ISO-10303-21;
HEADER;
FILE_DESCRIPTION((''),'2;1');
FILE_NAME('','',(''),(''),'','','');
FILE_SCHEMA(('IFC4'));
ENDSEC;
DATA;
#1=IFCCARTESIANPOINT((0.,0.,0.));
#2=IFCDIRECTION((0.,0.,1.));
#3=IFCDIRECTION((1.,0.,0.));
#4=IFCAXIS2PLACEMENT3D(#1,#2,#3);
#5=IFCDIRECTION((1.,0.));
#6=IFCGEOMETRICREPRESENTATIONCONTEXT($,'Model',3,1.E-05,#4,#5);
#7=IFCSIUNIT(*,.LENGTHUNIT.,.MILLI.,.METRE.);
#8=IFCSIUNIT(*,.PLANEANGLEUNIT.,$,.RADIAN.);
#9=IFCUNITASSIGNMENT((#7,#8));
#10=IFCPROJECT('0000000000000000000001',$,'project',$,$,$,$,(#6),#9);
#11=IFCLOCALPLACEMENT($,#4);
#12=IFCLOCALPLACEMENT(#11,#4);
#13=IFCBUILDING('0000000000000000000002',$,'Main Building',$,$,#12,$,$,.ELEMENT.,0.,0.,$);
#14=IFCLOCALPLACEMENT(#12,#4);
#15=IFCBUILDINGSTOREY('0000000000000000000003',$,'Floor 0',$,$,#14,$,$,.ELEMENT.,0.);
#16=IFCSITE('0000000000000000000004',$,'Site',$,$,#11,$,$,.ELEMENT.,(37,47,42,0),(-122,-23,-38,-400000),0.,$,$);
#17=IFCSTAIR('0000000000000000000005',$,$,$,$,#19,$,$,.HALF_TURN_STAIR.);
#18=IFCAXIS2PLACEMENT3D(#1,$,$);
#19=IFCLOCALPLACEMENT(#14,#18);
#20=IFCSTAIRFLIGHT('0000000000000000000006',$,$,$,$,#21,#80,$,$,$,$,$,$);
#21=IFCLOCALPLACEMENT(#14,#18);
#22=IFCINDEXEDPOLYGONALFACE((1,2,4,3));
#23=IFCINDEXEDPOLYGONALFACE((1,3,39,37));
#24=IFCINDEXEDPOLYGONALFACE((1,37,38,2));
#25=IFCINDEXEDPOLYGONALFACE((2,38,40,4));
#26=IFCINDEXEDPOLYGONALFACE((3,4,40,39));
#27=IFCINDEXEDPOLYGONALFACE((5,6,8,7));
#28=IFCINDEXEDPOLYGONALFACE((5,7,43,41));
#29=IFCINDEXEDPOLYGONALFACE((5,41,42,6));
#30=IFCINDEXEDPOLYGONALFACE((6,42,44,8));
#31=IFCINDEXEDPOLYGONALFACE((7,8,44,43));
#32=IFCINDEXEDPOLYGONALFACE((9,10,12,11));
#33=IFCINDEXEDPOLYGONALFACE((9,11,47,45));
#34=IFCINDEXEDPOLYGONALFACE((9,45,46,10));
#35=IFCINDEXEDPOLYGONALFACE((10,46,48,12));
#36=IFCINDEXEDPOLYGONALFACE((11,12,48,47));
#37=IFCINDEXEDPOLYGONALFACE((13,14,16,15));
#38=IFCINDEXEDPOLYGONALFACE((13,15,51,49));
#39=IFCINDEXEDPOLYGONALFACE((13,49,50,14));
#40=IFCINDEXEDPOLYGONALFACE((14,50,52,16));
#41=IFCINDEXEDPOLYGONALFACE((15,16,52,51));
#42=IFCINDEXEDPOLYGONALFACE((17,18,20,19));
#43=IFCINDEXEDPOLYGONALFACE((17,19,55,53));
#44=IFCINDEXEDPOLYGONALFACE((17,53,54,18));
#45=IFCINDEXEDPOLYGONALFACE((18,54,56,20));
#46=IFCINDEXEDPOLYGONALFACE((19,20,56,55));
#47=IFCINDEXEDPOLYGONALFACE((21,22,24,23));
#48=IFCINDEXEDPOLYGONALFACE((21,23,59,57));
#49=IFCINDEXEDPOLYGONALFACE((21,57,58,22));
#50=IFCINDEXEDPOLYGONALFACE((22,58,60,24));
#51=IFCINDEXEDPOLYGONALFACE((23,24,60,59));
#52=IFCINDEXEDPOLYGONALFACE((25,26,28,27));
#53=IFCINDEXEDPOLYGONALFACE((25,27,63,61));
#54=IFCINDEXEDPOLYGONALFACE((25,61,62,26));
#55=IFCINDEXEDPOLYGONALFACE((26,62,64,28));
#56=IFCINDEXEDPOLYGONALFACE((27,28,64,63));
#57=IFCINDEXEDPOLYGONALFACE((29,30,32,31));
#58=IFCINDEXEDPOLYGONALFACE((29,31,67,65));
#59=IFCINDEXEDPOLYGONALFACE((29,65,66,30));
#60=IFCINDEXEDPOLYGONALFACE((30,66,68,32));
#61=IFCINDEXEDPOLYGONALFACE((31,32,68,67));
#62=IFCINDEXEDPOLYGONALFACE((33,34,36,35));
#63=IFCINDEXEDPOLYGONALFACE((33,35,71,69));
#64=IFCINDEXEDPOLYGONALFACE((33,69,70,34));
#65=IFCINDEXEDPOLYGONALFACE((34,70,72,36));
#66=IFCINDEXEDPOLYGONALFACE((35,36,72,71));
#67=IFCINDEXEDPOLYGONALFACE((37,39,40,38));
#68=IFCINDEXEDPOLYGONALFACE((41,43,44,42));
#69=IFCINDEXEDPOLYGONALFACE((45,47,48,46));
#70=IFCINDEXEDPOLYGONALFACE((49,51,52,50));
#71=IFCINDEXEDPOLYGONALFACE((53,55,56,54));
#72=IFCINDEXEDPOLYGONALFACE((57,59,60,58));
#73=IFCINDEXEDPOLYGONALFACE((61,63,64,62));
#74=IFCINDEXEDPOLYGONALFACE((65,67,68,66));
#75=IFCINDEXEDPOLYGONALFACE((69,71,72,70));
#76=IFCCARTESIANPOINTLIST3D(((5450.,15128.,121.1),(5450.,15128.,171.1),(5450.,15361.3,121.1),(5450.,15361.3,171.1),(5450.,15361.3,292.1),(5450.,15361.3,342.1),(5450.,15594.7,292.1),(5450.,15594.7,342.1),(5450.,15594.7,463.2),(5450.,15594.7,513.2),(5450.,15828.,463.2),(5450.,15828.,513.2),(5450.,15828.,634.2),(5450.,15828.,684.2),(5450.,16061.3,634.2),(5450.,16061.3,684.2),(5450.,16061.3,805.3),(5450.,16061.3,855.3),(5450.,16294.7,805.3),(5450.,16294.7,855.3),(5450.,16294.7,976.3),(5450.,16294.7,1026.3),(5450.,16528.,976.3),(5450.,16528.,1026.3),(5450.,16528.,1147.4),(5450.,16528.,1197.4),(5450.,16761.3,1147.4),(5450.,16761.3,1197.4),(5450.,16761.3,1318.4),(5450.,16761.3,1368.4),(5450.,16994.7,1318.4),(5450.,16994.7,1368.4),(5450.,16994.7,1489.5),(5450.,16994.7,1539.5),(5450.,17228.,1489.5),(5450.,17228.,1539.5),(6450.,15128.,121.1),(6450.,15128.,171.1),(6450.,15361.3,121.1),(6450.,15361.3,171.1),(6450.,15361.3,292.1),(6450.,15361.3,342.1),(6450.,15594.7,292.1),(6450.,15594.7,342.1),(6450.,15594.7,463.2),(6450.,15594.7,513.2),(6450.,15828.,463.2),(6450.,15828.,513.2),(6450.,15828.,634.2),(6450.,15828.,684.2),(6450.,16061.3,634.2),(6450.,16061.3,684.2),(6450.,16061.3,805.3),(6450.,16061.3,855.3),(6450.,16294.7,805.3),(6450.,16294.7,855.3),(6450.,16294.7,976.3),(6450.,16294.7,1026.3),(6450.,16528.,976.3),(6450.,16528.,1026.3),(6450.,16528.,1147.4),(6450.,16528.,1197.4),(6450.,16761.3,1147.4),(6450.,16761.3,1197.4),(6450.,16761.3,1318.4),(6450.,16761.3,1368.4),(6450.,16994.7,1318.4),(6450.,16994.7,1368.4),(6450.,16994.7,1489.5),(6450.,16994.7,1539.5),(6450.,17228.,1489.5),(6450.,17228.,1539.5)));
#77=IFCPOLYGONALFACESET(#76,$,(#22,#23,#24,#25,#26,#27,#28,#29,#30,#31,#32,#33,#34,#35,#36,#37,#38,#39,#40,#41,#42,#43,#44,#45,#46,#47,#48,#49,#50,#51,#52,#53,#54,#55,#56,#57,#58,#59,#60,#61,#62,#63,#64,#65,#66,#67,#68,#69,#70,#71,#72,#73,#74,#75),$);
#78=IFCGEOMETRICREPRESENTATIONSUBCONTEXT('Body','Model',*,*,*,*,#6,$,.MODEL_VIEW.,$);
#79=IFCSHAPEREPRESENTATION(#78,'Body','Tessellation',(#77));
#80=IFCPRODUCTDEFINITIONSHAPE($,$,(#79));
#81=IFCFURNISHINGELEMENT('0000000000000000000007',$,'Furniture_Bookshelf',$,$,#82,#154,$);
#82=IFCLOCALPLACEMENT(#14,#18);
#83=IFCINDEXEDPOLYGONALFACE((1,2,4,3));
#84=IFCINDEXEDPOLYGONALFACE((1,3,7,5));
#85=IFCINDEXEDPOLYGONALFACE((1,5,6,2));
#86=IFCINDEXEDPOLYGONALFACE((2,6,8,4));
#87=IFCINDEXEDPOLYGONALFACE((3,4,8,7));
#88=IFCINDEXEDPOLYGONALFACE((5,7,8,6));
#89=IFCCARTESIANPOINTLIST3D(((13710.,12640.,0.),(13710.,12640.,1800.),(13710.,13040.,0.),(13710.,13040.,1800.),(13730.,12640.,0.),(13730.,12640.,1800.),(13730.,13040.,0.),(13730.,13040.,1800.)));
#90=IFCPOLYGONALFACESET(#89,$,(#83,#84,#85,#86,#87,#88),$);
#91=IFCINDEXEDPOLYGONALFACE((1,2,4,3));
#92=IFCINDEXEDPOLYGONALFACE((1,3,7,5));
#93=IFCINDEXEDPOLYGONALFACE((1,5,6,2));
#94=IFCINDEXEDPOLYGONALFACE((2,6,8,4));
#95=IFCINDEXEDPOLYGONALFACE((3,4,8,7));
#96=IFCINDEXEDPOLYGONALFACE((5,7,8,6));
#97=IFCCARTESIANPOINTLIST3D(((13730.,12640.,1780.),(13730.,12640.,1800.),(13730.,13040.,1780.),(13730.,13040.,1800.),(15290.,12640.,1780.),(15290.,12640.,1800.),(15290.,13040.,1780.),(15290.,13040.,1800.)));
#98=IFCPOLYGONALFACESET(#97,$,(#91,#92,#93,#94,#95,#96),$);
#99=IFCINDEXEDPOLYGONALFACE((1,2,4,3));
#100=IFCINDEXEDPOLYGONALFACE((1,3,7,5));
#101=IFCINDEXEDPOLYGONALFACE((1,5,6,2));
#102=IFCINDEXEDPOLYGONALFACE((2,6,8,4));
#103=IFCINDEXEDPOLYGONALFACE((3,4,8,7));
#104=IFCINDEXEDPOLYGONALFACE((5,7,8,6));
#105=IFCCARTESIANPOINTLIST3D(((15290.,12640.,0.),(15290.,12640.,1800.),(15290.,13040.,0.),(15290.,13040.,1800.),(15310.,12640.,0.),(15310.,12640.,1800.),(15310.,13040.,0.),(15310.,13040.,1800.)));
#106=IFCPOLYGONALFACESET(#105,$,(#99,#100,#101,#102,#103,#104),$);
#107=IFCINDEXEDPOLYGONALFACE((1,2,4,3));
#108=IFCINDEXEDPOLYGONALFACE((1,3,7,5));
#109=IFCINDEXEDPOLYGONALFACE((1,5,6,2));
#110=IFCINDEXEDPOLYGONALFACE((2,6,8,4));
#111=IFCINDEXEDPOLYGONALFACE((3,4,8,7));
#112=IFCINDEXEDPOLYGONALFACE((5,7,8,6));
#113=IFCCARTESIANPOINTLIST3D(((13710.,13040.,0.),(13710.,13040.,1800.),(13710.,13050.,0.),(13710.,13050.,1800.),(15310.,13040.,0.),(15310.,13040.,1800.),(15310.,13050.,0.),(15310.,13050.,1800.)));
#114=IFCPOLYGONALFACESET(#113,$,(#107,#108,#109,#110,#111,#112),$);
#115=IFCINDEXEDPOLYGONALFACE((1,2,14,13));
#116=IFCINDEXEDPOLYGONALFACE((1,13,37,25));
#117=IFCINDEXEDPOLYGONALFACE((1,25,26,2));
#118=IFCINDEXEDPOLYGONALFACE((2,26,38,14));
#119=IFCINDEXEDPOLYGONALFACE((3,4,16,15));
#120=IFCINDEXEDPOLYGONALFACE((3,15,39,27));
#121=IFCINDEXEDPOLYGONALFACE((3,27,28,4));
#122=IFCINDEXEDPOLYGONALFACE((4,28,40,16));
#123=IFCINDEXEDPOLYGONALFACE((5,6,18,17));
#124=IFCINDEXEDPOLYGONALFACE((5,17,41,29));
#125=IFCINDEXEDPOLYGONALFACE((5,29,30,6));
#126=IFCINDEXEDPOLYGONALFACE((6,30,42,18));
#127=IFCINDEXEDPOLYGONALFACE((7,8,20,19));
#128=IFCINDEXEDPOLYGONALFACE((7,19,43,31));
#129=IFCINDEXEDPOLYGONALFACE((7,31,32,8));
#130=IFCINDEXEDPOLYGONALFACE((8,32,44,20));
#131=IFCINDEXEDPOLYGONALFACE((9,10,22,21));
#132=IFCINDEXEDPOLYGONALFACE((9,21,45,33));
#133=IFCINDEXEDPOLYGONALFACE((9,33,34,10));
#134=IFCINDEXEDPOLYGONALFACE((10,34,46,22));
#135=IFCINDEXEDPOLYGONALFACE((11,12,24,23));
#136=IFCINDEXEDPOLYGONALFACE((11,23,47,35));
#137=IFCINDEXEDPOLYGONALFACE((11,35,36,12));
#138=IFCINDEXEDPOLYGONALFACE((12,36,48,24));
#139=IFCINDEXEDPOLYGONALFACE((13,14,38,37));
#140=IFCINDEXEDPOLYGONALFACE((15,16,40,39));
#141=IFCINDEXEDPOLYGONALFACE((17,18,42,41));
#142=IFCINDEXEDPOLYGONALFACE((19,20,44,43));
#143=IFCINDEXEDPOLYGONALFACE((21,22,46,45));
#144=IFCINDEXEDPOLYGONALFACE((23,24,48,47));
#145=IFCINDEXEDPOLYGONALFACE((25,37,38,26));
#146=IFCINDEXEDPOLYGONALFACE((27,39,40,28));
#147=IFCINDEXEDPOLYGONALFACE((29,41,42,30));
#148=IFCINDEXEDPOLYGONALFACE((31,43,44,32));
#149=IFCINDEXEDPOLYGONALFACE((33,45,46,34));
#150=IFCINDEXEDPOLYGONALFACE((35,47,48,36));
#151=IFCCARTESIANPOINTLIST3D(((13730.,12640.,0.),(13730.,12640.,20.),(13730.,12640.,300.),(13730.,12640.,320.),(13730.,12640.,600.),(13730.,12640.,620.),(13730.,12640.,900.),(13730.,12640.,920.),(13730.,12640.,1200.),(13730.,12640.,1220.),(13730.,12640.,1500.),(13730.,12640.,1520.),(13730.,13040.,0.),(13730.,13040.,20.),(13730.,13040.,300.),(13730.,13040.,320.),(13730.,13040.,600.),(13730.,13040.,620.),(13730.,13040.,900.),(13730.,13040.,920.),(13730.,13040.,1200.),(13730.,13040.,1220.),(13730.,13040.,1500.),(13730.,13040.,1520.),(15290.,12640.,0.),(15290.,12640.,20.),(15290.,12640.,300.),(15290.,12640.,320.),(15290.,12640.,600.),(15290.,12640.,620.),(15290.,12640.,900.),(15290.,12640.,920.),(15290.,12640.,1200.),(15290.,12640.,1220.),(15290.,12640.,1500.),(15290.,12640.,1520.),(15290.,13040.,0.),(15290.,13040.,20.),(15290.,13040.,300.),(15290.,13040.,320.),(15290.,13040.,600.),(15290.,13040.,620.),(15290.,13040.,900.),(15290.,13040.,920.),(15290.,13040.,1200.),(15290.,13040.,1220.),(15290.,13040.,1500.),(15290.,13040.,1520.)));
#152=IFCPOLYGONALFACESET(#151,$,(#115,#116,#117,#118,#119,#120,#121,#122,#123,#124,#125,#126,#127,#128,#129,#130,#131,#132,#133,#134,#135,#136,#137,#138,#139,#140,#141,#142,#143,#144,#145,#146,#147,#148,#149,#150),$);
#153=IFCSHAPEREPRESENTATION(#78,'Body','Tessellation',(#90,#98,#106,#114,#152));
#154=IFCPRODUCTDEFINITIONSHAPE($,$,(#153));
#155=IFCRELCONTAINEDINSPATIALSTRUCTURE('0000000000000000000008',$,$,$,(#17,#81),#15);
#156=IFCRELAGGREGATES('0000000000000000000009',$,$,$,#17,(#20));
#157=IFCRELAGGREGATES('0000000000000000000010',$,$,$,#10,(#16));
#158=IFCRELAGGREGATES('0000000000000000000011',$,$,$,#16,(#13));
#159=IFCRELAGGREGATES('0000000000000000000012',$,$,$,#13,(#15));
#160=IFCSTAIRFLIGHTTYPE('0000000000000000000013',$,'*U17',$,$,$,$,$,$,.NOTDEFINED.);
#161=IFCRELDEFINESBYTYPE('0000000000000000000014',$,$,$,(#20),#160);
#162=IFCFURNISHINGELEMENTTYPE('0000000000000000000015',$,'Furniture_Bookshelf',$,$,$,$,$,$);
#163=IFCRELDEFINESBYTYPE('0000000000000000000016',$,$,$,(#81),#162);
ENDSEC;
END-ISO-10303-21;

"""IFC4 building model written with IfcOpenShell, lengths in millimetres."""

from ifc_helpers import new_model, si_unit, direction, frame, frame_2d, origin_with_axes, origin_2d_with_axis, place, context, subcontext, project, spatial, rectangle, extrude, source, transform, mapped, type_object, type_shapes, element, aggregate, save


model = new_model("IFC4")

# Units and contexts
model_context = context("Model", 3, precision=1e-05, world=origin_with_axes(), true_north=direction((1.0, 0.0)))
body_context = subcontext(model_context, "Body", "Model", "MODEL_VIEW")
ifc_project = project(units=[si_unit("LENGTHUNIT", "METRE", prefix="MILLI"), si_unit("PLANEANGLEUNIT", "RADIAN")], contexts=[model_context])

# Site, building, storey
site_placement = place(None, origin_with_axes())
site = spatial("IfcSite", under=ifc_project, at=site_placement, Name="Site", CompositionType="ELEMENT", RefLatitude=(37, 47, 42, 0), RefLongitude=(-122, -23, -38, -400000), RefElevation=0.0)
building_placement = place(site_placement, origin_with_axes())
building = spatial("IfcBuilding", under=site, at=building_placement, Name="Main Building", CompositionType="ELEMENT", ElevationOfRefHeight=0.0, ElevationOfTerrain=0.0)
storey_placement = place(building_placement, origin_with_axes())
storey = spatial("IfcBuildingStorey", under=building, at=storey_placement, Name="Floor 0", CompositionType="ELEMENT", Elevation=0.0)

# Stair, stair flight
stair_placement = place(storey_placement, frame((8550.0, 15128.0, 3250.0), z_axis=(0.0, 0.0, 1.0), x_axis=(0.0, 1.0, 0.0)))
stair = element("IfcStair", 1, at=stair_placement, inside=storey, PredefinedType="HALF_TURN_STAIR")
stair_flight_type_1 = type_object("IfcStairFlightType", Name="*U17", PredefinedType="NOTDEFINED")
shared_shape_1 = source(origin_with_axes(), body_context, "Body", "SweptSolid", [
    extrude(rectangle(XDim=1000.0, YDim=233.3, at=frame_2d((0.0, 0.0), x_axis=(0.0, 1.0))), frame((1983.3, 2600.0, -1760.5), z_axis=(0.0, 0.0, 1.0), x_axis=(1.0, 0.0, 0.0)), (0.0, 0.0, 1.0), 50.0),
])
shared_shape_2 = source(origin_with_axes(), body_context, "Body", "MappedRepresentation", [
    mapped(shared_shape_1, transform((0.0, 0.0, 0.0), x_axis=(1.0, 0.0, 0.0), y_axis=(0.0, 1.0, 0.0), z_axis=(0.0, 0.0, 1.0), scale=1.0)),
    mapped(shared_shape_1, transform((-233.3, 0.0, -171.1), x_axis=(1.0, 0.0, 0.0), y_axis=(0.0, 1.0, 0.0), z_axis=(0.0, 0.0, 1.0), scale=1.0)),
    mapped(shared_shape_1, transform((-466.7, 0.0, -342.1), x_axis=(1.0, 0.0, 0.0), y_axis=(0.0, 1.0, 0.0), z_axis=(0.0, 0.0, 1.0), scale=1.0)),
    mapped(shared_shape_1, transform((-700.0, 0.0, -513.2), x_axis=(1.0, 0.0, 0.0), y_axis=(0.0, 1.0, 0.0), z_axis=(0.0, 0.0, 1.0), scale=1.0)),
    mapped(shared_shape_1, transform((-933.3, 0.0, -684.2), x_axis=(1.0, 0.0, 0.0), y_axis=(0.0, 1.0, 0.0), z_axis=(0.0, 0.0, 1.0), scale=1.0)),
    mapped(shared_shape_1, transform((-1166.7, 0.0, -855.3), x_axis=(1.0, 0.0, 0.0), y_axis=(0.0, 1.0, 0.0), z_axis=(0.0, 0.0, 1.0), scale=1.0)),
    mapped(shared_shape_1, transform((-1400.0, 0.0, -1026.3), x_axis=(1.0, 0.0, 0.0), y_axis=(0.0, 1.0, 0.0), z_axis=(0.0, 0.0, 1.0), scale=1.0)),
    mapped(shared_shape_1, transform((-1633.3, 0.0, -1197.4), x_axis=(1.0, 0.0, 0.0), y_axis=(0.0, 1.0, 0.0), z_axis=(0.0, 0.0, 1.0), scale=1.0)),
    mapped(shared_shape_1, transform((-1866.7, 0.0, -1368.4), x_axis=(1.0, 0.0, 0.0), y_axis=(0.0, 1.0, 0.0), z_axis=(0.0, 0.0, 1.0), scale=1.0)),
])
type_shapes(stair_flight_type_1, [shared_shape_2])
stair_flight_1_placement = place(stair_placement, origin_with_axes())
stair_flight_1 = element("IfcStairFlight", 2, at=stair_flight_1_placement, type_object=stair_flight_type_1, context=body_context, shape_type="MappedRepresentation", body=[
    mapped(shared_shape_2, transform((0.0, 0.0, 0.0), x_axis=(1.0, 0.0, 0.0), y_axis=(0.0, 1.0, 0.0), z_axis=(0.0, 0.0, 1.0), scale=1.0)),
])

# Furnishing element
furnishing_element_type_1 = type_object("IfcFurnishingElementType", Name="Furniture_Bookshelf")
shared_shape_3 = source(origin_with_axes(), body_context, "Body", "SweptSolid", [
    extrude(rectangle(XDim=400.0, YDim=20.0, at=frame_2d((0.0, 0.0), x_axis=(0.0, 1.0))), frame((10.0, 200.0, 0.0), z_axis=(0.0, 0.0, 1.0), x_axis=(1.0, 0.0, 0.0)), (0.0, 0.0, 1.0), 1800.0),
])
shared_shape_4 = source(origin_with_axes(), body_context, "Body", "SweptSolid", [
    extrude(rectangle(XDim=1560.0, YDim=400.0, at=origin_2d_with_axis()), frame((800.0, 200.0, 1780.0), z_axis=(0.0, 0.0, 1.0), x_axis=(1.0, 0.0, 0.0)), (0.0, 0.0, 1.0), 20.0),
])
shared_shape_5 = source(origin_with_axes(), body_context, "Body", "SweptSolid", [
    extrude(rectangle(XDim=400.0, YDim=20.0, at=frame_2d((0.0, 0.0), x_axis=(0.0, 1.0))), frame((1590.0, 200.0, 0.0), z_axis=(0.0, 0.0, 1.0), x_axis=(1.0, 0.0, 0.0)), (0.0, 0.0, 1.0), 1800.0),
])
shared_shape_6 = source(origin_with_axes(), body_context, "Body", "SweptSolid", [
    extrude(rectangle(XDim=1600.0, YDim=10.0, at=origin_2d_with_axis()), frame((800.0, 405.0, 0.0), z_axis=(0.0, 0.0, 1.0), x_axis=(1.0, 0.0, 0.0)), (0.0, 0.0, 1.0), 1800.0),
])
shared_shape_7 = source(origin_with_axes(), body_context, "Body", "SweptSolid", [
    extrude(rectangle(XDim=1560.0, YDim=400.0, at=origin_2d_with_axis()), frame((200.0, 50.0, -10.0), z_axis=(0.0, 0.0, 1.0), x_axis=(1.0, 0.0, 0.0)), (0.0, 0.0, 1.0), 20.0),
])
shared_shape_8 = source(origin_with_axes(), body_context, "Body", "MappedRepresentation", [
    mapped(shared_shape_7, transform((0.0, 0.0, 0.0), x_axis=(1.0, 0.0, 0.0), y_axis=(0.0, 1.0, 0.0), z_axis=(0.0, 0.0, 1.0), scale=1.0)),
    mapped(shared_shape_7, transform((0.0, 0.0, 300.0), x_axis=(1.0, 0.0, 0.0), y_axis=(0.0, 1.0, 0.0), z_axis=(0.0, 0.0, 1.0), scale=1.0)),
    mapped(shared_shape_7, transform((0.0, 0.0, 600.0), x_axis=(1.0, 0.0, 0.0), y_axis=(0.0, 1.0, 0.0), z_axis=(0.0, 0.0, 1.0), scale=1.0)),
    mapped(shared_shape_7, transform((0.0, 0.0, 900.0), x_axis=(1.0, 0.0, 0.0), y_axis=(0.0, 1.0, 0.0), z_axis=(0.0, 0.0, 1.0), scale=1.0)),
    mapped(shared_shape_7, transform((0.0, 0.0, 1200.0), x_axis=(1.0, 0.0, 0.0), y_axis=(0.0, 1.0, 0.0), z_axis=(0.0, 0.0, 1.0), scale=1.0)),
    mapped(shared_shape_7, transform((0.0, 0.0, 1500.0), x_axis=(1.0, 0.0, 0.0), y_axis=(0.0, 1.0, 0.0), z_axis=(0.0, 0.0, 1.0), scale=1.0)),
])
shared_shape_9 = source(origin_with_axes(), body_context, "Body", "MappedRepresentation", [
    mapped(shared_shape_3, transform((0.0, 0.0, 0.0), x_axis=(1.0, 0.0, 0.0), y_axis=(0.0, 1.0, 0.0), z_axis=(0.0, 0.0, 1.0), scale=1.0)),
    mapped(shared_shape_4, transform((0.0, 0.0, 0.0), x_axis=(1.0, 0.0, 0.0), y_axis=(0.0, 1.0, 0.0), z_axis=(0.0, 0.0, 1.0), scale=1.0)),
    mapped(shared_shape_5, transform((0.0, 0.0, 0.0), x_axis=(1.0, 0.0, 0.0), y_axis=(0.0, 1.0, 0.0), z_axis=(0.0, 0.0, 1.0), scale=1.0)),
    mapped(shared_shape_6, transform((0.0, 0.0, 0.0), x_axis=(1.0, 0.0, 0.0), y_axis=(0.0, 1.0, 0.0), z_axis=(0.0, 0.0, 1.0), scale=1.0)),
    mapped(shared_shape_8, transform((600.0, 150.0, 10.0), x_axis=(1.0, 0.0, 0.0), y_axis=(0.0, 1.0, 0.0), z_axis=(0.0, 0.0, 1.0), scale=1.0)),
])
type_shapes(furnishing_element_type_1, [shared_shape_9])
for number, where, z_axis, x_axis, name in (
    (3, (13710.0, 12640.0, 0.0), (0.0, 0.0, 1.0), (1.0, 0.0, 0.0), "Furniture_Bookshelf"),
):
    element("IfcFurnishingElement", number, at=place(storey_placement, frame(where, z_axis=z_axis, x_axis=x_axis)), inside=storey, type_object=furnishing_element_type_1, Name=name, context=body_context, shape_type="MappedRepresentation", body=[
        mapped(shared_shape_9, transform((0.0, 0.0, 0.0), x_axis=(1.0, 0.0, 0.0), y_axis=(0.0, 1.0, 0.0), z_axis=(0.0, 0.0, 1.0), scale=1.0)),
    ])

aggregate(stair, [stair_flight_1])

save(model, "model.ifc")
